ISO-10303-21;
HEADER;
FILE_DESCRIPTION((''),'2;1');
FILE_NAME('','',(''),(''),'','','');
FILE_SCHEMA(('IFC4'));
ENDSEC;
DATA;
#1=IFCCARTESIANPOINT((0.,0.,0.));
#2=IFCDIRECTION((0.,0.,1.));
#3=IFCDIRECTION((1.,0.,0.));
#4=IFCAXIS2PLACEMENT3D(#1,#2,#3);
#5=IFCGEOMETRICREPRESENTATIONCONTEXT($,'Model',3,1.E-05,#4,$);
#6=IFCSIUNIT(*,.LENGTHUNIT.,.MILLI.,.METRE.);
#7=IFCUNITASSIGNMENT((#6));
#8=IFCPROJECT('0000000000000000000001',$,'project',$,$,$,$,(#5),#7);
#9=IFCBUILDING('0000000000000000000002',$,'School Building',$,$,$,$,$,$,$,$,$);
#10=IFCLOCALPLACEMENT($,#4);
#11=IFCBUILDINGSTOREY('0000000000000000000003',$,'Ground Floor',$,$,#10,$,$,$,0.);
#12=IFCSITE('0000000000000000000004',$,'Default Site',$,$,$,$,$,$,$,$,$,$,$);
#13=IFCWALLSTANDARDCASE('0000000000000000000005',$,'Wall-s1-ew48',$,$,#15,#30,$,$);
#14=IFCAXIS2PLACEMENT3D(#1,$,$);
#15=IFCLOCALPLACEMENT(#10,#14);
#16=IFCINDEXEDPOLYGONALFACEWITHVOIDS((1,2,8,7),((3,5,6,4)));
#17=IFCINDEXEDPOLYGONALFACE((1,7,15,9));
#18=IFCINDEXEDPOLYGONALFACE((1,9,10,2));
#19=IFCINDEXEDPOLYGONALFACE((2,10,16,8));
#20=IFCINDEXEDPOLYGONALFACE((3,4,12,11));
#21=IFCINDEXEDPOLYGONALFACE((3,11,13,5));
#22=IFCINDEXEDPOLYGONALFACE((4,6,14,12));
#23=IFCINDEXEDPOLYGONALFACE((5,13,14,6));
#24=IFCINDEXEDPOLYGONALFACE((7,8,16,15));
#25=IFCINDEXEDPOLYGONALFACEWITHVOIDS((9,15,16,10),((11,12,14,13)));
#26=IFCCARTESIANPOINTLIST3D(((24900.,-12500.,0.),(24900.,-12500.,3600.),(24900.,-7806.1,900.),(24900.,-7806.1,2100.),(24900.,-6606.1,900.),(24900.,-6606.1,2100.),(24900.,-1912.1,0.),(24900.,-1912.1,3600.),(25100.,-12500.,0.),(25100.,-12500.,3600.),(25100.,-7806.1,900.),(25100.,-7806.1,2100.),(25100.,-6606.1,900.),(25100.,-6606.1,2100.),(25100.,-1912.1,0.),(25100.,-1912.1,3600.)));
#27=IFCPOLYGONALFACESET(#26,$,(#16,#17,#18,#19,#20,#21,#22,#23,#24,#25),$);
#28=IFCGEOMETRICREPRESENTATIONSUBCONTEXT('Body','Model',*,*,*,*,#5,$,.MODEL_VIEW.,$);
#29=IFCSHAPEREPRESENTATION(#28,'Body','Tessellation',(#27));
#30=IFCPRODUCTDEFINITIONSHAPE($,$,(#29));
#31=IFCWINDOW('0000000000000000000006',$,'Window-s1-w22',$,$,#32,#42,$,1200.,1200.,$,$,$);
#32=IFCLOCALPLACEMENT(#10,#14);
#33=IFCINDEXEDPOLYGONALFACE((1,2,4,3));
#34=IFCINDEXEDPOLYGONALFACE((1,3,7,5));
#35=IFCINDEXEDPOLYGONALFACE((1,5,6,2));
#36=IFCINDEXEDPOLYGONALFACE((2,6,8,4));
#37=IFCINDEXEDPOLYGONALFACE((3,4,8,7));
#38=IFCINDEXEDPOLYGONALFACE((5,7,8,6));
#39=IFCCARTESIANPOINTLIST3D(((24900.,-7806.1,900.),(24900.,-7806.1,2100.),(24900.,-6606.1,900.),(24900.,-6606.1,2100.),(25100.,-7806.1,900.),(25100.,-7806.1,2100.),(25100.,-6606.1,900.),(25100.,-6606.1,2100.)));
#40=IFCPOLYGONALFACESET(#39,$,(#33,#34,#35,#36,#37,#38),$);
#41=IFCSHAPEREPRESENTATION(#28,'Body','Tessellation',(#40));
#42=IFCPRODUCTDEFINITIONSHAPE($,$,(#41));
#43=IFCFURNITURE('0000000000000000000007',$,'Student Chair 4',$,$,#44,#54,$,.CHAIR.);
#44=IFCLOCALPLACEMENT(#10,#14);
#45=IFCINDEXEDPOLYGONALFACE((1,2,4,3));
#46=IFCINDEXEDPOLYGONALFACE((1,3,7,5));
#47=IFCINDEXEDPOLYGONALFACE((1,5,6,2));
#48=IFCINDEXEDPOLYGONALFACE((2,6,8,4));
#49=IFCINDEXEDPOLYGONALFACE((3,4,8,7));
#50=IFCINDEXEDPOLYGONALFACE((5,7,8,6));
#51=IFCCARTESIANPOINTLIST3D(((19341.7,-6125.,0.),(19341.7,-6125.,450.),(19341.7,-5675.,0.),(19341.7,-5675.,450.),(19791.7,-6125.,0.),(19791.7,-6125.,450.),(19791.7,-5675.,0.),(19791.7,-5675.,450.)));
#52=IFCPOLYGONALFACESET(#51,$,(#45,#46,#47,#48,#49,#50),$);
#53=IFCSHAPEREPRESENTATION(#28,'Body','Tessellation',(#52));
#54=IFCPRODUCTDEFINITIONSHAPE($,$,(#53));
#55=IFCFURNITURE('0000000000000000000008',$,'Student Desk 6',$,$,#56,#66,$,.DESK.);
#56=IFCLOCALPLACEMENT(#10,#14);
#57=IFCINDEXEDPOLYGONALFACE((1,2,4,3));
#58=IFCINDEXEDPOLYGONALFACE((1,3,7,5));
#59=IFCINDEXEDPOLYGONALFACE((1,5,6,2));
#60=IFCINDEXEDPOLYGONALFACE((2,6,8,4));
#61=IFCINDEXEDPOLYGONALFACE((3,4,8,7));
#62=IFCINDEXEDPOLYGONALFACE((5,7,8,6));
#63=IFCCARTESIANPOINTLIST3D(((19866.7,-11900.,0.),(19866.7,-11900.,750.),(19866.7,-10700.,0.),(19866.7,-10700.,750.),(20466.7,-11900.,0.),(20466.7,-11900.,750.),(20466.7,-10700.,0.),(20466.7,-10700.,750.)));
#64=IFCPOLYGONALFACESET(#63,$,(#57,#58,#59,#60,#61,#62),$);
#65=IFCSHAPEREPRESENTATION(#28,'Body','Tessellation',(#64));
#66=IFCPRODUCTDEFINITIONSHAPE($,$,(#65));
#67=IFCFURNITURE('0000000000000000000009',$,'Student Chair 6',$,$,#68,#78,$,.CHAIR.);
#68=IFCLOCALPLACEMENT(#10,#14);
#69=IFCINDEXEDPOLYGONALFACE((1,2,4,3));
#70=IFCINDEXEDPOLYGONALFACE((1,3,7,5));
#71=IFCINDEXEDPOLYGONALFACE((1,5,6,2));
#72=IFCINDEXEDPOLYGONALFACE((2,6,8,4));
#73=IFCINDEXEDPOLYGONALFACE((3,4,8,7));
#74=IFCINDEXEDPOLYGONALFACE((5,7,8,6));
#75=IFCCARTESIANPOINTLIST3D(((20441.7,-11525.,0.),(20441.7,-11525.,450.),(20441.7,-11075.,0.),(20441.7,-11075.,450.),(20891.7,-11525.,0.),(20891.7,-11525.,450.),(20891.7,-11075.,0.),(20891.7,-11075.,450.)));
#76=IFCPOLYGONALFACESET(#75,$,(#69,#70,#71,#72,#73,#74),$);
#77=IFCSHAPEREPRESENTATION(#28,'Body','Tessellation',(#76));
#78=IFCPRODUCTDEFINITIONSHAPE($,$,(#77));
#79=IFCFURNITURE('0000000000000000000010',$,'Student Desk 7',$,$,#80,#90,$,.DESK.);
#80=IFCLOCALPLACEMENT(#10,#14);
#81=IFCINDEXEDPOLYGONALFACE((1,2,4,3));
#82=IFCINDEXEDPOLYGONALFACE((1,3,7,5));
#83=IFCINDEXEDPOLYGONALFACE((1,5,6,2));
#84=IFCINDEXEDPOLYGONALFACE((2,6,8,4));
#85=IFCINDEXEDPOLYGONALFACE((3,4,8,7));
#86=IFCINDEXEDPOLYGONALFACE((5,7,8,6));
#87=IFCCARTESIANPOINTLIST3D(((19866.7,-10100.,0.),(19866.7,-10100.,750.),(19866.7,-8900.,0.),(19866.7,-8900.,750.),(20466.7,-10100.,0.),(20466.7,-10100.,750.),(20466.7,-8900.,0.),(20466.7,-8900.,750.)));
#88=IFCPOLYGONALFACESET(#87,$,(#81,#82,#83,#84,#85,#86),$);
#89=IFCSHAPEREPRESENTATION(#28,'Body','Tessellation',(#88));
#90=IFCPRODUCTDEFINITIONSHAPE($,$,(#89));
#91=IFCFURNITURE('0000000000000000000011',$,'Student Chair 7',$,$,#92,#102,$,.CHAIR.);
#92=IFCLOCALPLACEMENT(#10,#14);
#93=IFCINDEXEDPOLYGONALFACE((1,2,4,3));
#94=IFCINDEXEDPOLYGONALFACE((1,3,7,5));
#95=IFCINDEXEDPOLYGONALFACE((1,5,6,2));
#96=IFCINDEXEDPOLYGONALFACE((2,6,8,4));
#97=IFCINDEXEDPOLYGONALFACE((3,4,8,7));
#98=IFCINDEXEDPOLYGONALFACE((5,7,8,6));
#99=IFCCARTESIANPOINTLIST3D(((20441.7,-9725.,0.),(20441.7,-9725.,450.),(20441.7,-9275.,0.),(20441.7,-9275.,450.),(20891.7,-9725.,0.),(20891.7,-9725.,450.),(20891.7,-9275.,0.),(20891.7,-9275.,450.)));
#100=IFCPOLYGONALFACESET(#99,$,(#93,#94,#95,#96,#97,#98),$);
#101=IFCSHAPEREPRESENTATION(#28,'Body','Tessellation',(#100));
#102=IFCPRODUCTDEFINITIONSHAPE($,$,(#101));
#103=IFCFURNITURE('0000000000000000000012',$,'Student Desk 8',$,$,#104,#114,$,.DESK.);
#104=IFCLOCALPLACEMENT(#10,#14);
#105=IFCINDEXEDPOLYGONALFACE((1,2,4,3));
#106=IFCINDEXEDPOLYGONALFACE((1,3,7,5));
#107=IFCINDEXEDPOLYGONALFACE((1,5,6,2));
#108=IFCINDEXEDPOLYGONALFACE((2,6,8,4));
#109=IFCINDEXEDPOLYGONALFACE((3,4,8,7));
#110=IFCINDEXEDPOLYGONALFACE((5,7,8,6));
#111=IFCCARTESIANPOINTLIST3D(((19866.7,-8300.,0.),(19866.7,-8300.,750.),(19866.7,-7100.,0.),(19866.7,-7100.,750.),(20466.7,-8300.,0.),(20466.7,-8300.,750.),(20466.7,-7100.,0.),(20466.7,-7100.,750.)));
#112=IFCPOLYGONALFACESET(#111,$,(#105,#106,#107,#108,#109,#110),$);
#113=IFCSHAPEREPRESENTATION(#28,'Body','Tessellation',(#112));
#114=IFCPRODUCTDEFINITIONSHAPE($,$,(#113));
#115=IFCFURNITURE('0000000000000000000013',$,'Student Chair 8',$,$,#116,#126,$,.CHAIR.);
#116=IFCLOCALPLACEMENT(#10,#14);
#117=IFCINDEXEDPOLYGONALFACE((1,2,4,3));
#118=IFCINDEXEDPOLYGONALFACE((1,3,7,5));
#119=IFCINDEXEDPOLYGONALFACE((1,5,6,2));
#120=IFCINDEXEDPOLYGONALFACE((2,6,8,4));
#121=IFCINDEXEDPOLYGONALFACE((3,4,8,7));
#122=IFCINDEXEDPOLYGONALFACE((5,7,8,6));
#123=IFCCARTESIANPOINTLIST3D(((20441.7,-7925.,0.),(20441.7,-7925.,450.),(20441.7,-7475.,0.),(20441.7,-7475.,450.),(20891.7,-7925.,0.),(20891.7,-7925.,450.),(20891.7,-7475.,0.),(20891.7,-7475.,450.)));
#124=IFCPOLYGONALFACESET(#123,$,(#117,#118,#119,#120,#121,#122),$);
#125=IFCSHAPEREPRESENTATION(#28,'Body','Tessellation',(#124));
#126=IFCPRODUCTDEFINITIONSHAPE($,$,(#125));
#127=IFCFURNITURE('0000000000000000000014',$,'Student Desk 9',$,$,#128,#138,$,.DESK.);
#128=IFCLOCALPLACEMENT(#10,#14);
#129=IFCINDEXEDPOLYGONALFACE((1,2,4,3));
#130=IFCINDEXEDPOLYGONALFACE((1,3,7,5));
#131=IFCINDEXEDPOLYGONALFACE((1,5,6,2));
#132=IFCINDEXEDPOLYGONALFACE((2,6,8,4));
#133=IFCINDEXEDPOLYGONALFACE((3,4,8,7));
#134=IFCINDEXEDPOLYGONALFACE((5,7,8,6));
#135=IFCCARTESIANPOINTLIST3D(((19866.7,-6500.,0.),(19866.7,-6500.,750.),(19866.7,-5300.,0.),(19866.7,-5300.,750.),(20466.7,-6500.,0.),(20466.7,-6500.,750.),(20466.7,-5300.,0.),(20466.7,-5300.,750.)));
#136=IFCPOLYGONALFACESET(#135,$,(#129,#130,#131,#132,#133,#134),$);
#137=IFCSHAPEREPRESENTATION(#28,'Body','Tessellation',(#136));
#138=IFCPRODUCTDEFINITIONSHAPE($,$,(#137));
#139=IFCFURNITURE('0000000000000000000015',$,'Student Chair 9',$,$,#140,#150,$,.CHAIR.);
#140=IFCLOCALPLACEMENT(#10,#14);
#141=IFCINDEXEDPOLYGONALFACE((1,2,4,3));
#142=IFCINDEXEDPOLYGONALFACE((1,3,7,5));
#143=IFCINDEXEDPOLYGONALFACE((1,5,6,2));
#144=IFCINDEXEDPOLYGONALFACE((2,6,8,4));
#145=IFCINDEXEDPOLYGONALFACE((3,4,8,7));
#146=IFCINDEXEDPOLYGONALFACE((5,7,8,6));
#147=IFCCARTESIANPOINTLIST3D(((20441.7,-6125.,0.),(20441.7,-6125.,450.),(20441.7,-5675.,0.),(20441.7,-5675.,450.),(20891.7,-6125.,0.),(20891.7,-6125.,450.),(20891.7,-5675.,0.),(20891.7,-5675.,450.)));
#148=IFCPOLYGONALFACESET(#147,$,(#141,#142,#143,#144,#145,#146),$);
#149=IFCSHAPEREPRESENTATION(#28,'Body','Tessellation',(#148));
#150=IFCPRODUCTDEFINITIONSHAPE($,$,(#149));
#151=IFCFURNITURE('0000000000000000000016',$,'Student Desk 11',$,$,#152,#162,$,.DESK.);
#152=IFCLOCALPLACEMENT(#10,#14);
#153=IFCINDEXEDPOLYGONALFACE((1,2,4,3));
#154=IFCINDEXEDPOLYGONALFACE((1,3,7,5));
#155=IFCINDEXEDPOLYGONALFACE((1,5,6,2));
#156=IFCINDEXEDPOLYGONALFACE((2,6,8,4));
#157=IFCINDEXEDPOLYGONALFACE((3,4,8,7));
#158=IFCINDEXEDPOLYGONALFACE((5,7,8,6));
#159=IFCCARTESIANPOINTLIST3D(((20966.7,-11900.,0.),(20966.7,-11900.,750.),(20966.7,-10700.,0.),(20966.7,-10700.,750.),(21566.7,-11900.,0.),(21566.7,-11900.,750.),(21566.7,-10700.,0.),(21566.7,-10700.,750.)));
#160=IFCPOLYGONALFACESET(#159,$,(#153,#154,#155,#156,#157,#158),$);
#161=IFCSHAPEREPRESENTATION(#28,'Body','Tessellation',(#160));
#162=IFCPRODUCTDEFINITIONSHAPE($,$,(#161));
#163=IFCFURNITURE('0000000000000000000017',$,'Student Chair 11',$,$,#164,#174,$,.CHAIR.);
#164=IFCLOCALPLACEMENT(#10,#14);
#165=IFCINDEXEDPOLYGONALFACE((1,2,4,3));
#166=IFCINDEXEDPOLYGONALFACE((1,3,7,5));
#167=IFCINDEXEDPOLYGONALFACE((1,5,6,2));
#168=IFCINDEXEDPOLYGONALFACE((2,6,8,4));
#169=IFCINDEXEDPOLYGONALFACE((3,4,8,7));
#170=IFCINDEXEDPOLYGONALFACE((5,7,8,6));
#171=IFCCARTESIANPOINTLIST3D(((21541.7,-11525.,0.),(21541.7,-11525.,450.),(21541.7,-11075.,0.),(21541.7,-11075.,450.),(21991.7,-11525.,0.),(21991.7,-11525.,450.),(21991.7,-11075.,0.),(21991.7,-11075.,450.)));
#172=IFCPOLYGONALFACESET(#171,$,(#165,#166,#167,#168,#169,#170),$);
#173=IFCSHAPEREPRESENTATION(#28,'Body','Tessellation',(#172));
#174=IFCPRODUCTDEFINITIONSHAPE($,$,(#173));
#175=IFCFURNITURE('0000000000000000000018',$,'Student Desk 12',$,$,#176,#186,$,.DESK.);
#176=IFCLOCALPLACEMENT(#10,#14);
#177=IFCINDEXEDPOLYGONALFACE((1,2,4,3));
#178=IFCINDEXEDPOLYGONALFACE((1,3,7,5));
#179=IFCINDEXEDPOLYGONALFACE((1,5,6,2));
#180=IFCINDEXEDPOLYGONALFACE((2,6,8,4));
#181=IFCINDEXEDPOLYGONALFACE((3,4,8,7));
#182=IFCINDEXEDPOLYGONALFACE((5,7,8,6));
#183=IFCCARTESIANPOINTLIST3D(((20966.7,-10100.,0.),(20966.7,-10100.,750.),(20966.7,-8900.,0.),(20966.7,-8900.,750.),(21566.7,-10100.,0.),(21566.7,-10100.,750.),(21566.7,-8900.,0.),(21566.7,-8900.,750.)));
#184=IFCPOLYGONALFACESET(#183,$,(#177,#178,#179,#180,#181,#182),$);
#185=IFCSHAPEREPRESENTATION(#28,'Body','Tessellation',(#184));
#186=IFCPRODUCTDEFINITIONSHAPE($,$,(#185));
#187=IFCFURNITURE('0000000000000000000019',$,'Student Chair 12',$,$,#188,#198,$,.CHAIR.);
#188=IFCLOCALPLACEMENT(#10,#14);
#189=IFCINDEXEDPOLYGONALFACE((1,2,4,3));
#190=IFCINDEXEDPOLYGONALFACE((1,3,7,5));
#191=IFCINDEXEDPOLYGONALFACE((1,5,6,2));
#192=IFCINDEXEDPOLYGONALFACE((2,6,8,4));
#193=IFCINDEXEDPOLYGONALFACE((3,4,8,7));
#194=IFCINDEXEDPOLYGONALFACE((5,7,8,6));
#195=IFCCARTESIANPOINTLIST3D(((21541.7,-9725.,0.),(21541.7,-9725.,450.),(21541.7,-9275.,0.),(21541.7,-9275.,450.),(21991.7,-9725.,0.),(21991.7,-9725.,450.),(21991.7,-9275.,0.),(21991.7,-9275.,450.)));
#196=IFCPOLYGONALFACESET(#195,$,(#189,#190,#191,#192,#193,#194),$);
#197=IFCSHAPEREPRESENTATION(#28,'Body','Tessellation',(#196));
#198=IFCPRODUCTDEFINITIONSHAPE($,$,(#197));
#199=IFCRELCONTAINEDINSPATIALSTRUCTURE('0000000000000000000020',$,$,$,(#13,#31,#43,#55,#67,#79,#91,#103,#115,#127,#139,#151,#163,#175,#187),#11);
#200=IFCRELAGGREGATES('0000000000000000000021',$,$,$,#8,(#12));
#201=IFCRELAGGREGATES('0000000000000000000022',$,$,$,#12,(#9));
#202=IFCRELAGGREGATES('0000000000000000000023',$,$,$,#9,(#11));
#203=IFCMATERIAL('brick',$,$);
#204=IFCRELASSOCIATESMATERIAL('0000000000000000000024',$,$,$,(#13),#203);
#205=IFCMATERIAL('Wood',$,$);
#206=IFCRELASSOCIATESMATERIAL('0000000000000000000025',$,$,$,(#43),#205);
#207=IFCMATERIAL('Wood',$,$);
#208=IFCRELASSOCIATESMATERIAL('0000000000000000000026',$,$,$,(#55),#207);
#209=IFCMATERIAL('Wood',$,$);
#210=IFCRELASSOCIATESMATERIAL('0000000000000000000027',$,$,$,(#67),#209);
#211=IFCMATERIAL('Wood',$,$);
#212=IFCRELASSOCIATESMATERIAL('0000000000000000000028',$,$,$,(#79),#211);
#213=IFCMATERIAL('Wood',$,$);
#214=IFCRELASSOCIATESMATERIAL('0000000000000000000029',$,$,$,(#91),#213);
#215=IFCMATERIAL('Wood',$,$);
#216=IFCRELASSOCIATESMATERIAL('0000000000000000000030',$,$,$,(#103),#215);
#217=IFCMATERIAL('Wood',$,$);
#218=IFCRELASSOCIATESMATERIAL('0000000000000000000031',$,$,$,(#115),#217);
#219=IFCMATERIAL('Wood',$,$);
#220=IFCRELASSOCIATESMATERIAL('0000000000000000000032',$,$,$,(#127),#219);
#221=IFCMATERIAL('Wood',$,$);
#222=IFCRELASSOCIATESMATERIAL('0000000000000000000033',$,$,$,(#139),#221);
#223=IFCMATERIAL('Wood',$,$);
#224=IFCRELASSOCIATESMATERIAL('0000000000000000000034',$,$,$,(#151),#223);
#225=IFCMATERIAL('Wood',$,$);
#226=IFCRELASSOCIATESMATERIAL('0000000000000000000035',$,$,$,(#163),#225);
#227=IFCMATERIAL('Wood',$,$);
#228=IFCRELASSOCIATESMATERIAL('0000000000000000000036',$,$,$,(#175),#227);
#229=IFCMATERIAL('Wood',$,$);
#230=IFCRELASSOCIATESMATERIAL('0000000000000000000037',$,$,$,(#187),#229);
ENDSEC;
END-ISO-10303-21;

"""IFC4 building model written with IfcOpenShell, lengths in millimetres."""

from ifc_helpers import new_model, si_unit, frame, frame_2d, origin_with_axes, origin_2d, place, context, subcontext, project, spatial, rectangle, extrude, material, element, fill, save


model = new_model("IFC4")

# Units and contexts
model_context = context("Model", 3, precision=1e-05, world=origin_with_axes())
body_context = subcontext(model_context, "Body", "Model", "MODEL_VIEW")
ifc_project = project(units=[si_unit("LENGTHUNIT", "METRE", prefix="MILLI")], contexts=[model_context])

# Site, building, storey
site = spatial("IfcSite", under=ifc_project, Name="Default Site")
building = spatial("IfcBuilding", under=site, Name="School Building")
storey_placement = place(None, origin_with_axes())
storey = spatial("IfcBuildingStorey", under=building, at=storey_placement, Name="Ground Floor", Elevation=0.0)

# Wall, opening, window
ifc_material_1 = material(Name="brick")
wall_placement = place(storey_placement, frame((25000.0, -12500.0, 0.0), z_axis=(0.0, 0.0, 1.0), x_axis=(0.0, 1.0, 0.0)))
wall = element("IfcWallStandardCase", 1, at=wall_placement, inside=storey, material=ifc_material_1, Name="Wall-s1-ew48", context=body_context, shape_type="SweptSolid", body=[
    extrude(rectangle(XDim=10587.9, YDim=200.0, at=frame_2d((5293.9, 0.0))), origin_with_axes(), (0.0, 0.0, 1.0), 3600.0),
])
opening_placement = place(wall_placement, frame((4693.9, 0.0, 900.0), z_axis=(0.0, 0.0, 1.0), x_axis=(1.0, 0.0, 0.0)))
opening = element("IfcOpeningElement", 2, at=opening_placement, cuts=wall, context=body_context, shape_type="SweptSolid", body=[
    extrude(rectangle(XDim=1200.0, YDim=400.0, at=frame_2d((600.0, 0.0))), origin_with_axes(), (0.0, 0.0, 1.0), 1200.0),
])
window_placement = place(storey_placement, frame((25000.0, -7806.1, 900.0), z_axis=(0.0, 0.0, 1.0), x_axis=(0.0, 1.0, 0.0)))
window = element("IfcWindow", 3, at=window_placement, inside=storey, Name="Window-s1-w22", OverallHeight=1200.0, OverallWidth=1200.0, context=body_context, shape_type="SweptSolid", body=[
    extrude(rectangle(XDim=1200.0, YDim=200.0, at=frame_2d((600.0, 0.0))), origin_with_axes(), (0.0, 0.0, 1.0), 1200.0),
])
fill(opening, window)

# Furniture
ifc_material_2 = material(Name="Wood")
furniture_1_placement = place(storey_placement, frame((19566.7, -5900.0, 0.0), z_axis=(0.0, 0.0, 1.0), x_axis=(1.0, 0.0, 0.0)))
element("IfcFurniture", 4, at=furniture_1_placement, inside=storey, material=ifc_material_2, Name="Student Chair 4", PredefinedType="CHAIR", context=body_context, shape_type="SweptSolid", body=[
    extrude(rectangle(XDim=450.0, YDim=450.0, at=origin_2d()), origin_with_axes(), (0.0, 0.0, 1.0), 450.0),
])
ifc_material_3 = material(Name="Wood")
furniture_2_placement = place(storey_placement, frame((20166.7, -11300.0, 0.0), z_axis=(0.0, 0.0, 1.0), x_axis=(0.0, 1.0, 0.0)))
element("IfcFurniture", 5, at=furniture_2_placement, inside=storey, material=ifc_material_3, Name="Student Desk 6", PredefinedType="DESK", context=body_context, shape_type="SweptSolid", body=[
    extrude(rectangle(XDim=1200.0, YDim=600.0, at=origin_2d()), origin_with_axes(), (0.0, 0.0, 1.0), 750.0),
])
ifc_material_4 = material(Name="Wood")
furniture_3_placement = place(storey_placement, frame((20666.7, -11300.0, 0.0), z_axis=(0.0, 0.0, 1.0), x_axis=(1.0, 0.0, 0.0)))
element("IfcFurniture", 6, at=furniture_3_placement, inside=storey, material=ifc_material_4, Name="Student Chair 6", PredefinedType="CHAIR", context=body_context, shape_type="SweptSolid", body=[
    extrude(rectangle(XDim=450.0, YDim=450.0, at=origin_2d()), origin_with_axes(), (0.0, 0.0, 1.0), 450.0),
])
ifc_material_5 = material(Name="Wood")
furniture_4_placement = place(storey_placement, frame((20166.7, -9500.0, 0.0), z_axis=(0.0, 0.0, 1.0), x_axis=(0.0, 1.0, 0.0)))
element("IfcFurniture", 7, at=furniture_4_placement, inside=storey, material=ifc_material_5, Name="Student Desk 7", PredefinedType="DESK", context=body_context, shape_type="SweptSolid", body=[
    extrude(rectangle(XDim=1200.0, YDim=600.0, at=origin_2d()), origin_with_axes(), (0.0, 0.0, 1.0), 750.0),
])
ifc_material_6 = material(Name="Wood")
furniture_5_placement = place(storey_placement, frame((20666.7, -9500.0, 0.0), z_axis=(0.0, 0.0, 1.0), x_axis=(1.0, 0.0, 0.0)))
element("IfcFurniture", 8, at=furniture_5_placement, inside=storey, material=ifc_material_6, Name="Student Chair 7", PredefinedType="CHAIR", context=body_context, shape_type="SweptSolid", body=[
    extrude(rectangle(XDim=450.0, YDim=450.0, at=origin_2d()), origin_with_axes(), (0.0, 0.0, 1.0), 450.0),
])
ifc_material_7 = material(Name="Wood")
furniture_6_placement = place(storey_placement, frame((20166.7, -7700.0, 0.0), z_axis=(0.0, 0.0, 1.0), x_axis=(0.0, 1.0, 0.0)))
element("IfcFurniture", 9, at=furniture_6_placement, inside=storey, material=ifc_material_7, Name="Student Desk 8", PredefinedType="DESK", context=body_context, shape_type="SweptSolid", body=[
    extrude(rectangle(XDim=1200.0, YDim=600.0, at=origin_2d()), origin_with_axes(), (0.0, 0.0, 1.0), 750.0),
])
ifc_material_8 = material(Name="Wood")
furniture_7_placement = place(storey_placement, frame((20666.7, -7700.0, 0.0), z_axis=(0.0, 0.0, 1.0), x_axis=(1.0, 0.0, 0.0)))
element("IfcFurniture", 10, at=furniture_7_placement, inside=storey, material=ifc_material_8, Name="Student Chair 8", PredefinedType="CHAIR", context=body_context, shape_type="SweptSolid", body=[
    extrude(rectangle(XDim=450.0, YDim=450.0, at=origin_2d()), origin_with_axes(), (0.0, 0.0, 1.0), 450.0),
])
ifc_material_9 = material(Name="Wood")
furniture_8_placement = place(storey_placement, frame((20166.7, -5900.0, 0.0), z_axis=(0.0, 0.0, 1.0), x_axis=(0.0, 1.0, 0.0)))
element("IfcFurniture", 11, at=furniture_8_placement, inside=storey, material=ifc_material_9, Name="Student Desk 9", PredefinedType="DESK", context=body_context, shape_type="SweptSolid", body=[
    extrude(rectangle(XDim=1200.0, YDim=600.0, at=origin_2d()), origin_with_axes(), (0.0, 0.0, 1.0), 750.0),
])
ifc_material_10 = material(Name="Wood")
furniture_9_placement = place(storey_placement, frame((20666.7, -5900.0, 0.0), z_axis=(0.0, 0.0, 1.0), x_axis=(1.0, 0.0, 0.0)))
element("IfcFurniture", 12, at=furniture_9_placement, inside=storey, material=ifc_material_10, Name="Student Chair 9", PredefinedType="CHAIR", context=body_context, shape_type="SweptSolid", body=[
    extrude(rectangle(XDim=450.0, YDim=450.0, at=origin_2d()), origin_with_axes(), (0.0, 0.0, 1.0), 450.0),
])
ifc_material_11 = material(Name="Wood")
furniture_10_placement = place(storey_placement, frame((21266.7, -11300.0, 0.0), z_axis=(0.0, 0.0, 1.0), x_axis=(0.0, 1.0, 0.0)))
element("IfcFurniture", 13, at=furniture_10_placement, inside=storey, material=ifc_material_11, Name="Student Desk 11", PredefinedType="DESK", context=body_context, shape_type="SweptSolid", body=[
    extrude(rectangle(XDim=1200.0, YDim=600.0, at=origin_2d()), origin_with_axes(), (0.0, 0.0, 1.0), 750.0),
])
ifc_material_12 = material(Name="Wood")
furniture_11_placement = place(storey_placement, frame((21766.7, -11300.0, 0.0), z_axis=(0.0, 0.0, 1.0), x_axis=(1.0, 0.0, 0.0)))
element("IfcFurniture", 14, at=furniture_11_placement, inside=storey, material=ifc_material_12, Name="Student Chair 11", PredefinedType="CHAIR", context=body_context, shape_type="SweptSolid", body=[
    extrude(rectangle(XDim=450.0, YDim=450.0, at=origin_2d()), origin_with_axes(), (0.0, 0.0, 1.0), 450.0),
])
ifc_material_13 = material(Name="Wood")
furniture_12_placement = place(storey_placement, frame((21266.7, -9500.0, 0.0), z_axis=(0.0, 0.0, 1.0), x_axis=(0.0, 1.0, 0.0)))
element("IfcFurniture", 15, at=furniture_12_placement, inside=storey, material=ifc_material_13, Name="Student Desk 12", PredefinedType="DESK", context=body_context, shape_type="SweptSolid", body=[
    extrude(rectangle(XDim=1200.0, YDim=600.0, at=origin_2d()), origin_with_axes(), (0.0, 0.0, 1.0), 750.0),
])
ifc_material_14 = material(Name="Wood")
furniture_13_placement = place(storey_placement, frame((21766.7, -9500.0, 0.0), z_axis=(0.0, 0.0, 1.0), x_axis=(1.0, 0.0, 0.0)))
element("IfcFurniture", 16, at=furniture_13_placement, inside=storey, material=ifc_material_14, Name="Student Chair 12", PredefinedType="CHAIR", context=body_context, shape_type="SweptSolid", body=[
    extrude(rectangle(XDim=450.0, YDim=450.0, at=origin_2d()), origin_with_axes(), (0.0, 0.0, 1.0), 450.0),
])

save(model, "model.ifc")
